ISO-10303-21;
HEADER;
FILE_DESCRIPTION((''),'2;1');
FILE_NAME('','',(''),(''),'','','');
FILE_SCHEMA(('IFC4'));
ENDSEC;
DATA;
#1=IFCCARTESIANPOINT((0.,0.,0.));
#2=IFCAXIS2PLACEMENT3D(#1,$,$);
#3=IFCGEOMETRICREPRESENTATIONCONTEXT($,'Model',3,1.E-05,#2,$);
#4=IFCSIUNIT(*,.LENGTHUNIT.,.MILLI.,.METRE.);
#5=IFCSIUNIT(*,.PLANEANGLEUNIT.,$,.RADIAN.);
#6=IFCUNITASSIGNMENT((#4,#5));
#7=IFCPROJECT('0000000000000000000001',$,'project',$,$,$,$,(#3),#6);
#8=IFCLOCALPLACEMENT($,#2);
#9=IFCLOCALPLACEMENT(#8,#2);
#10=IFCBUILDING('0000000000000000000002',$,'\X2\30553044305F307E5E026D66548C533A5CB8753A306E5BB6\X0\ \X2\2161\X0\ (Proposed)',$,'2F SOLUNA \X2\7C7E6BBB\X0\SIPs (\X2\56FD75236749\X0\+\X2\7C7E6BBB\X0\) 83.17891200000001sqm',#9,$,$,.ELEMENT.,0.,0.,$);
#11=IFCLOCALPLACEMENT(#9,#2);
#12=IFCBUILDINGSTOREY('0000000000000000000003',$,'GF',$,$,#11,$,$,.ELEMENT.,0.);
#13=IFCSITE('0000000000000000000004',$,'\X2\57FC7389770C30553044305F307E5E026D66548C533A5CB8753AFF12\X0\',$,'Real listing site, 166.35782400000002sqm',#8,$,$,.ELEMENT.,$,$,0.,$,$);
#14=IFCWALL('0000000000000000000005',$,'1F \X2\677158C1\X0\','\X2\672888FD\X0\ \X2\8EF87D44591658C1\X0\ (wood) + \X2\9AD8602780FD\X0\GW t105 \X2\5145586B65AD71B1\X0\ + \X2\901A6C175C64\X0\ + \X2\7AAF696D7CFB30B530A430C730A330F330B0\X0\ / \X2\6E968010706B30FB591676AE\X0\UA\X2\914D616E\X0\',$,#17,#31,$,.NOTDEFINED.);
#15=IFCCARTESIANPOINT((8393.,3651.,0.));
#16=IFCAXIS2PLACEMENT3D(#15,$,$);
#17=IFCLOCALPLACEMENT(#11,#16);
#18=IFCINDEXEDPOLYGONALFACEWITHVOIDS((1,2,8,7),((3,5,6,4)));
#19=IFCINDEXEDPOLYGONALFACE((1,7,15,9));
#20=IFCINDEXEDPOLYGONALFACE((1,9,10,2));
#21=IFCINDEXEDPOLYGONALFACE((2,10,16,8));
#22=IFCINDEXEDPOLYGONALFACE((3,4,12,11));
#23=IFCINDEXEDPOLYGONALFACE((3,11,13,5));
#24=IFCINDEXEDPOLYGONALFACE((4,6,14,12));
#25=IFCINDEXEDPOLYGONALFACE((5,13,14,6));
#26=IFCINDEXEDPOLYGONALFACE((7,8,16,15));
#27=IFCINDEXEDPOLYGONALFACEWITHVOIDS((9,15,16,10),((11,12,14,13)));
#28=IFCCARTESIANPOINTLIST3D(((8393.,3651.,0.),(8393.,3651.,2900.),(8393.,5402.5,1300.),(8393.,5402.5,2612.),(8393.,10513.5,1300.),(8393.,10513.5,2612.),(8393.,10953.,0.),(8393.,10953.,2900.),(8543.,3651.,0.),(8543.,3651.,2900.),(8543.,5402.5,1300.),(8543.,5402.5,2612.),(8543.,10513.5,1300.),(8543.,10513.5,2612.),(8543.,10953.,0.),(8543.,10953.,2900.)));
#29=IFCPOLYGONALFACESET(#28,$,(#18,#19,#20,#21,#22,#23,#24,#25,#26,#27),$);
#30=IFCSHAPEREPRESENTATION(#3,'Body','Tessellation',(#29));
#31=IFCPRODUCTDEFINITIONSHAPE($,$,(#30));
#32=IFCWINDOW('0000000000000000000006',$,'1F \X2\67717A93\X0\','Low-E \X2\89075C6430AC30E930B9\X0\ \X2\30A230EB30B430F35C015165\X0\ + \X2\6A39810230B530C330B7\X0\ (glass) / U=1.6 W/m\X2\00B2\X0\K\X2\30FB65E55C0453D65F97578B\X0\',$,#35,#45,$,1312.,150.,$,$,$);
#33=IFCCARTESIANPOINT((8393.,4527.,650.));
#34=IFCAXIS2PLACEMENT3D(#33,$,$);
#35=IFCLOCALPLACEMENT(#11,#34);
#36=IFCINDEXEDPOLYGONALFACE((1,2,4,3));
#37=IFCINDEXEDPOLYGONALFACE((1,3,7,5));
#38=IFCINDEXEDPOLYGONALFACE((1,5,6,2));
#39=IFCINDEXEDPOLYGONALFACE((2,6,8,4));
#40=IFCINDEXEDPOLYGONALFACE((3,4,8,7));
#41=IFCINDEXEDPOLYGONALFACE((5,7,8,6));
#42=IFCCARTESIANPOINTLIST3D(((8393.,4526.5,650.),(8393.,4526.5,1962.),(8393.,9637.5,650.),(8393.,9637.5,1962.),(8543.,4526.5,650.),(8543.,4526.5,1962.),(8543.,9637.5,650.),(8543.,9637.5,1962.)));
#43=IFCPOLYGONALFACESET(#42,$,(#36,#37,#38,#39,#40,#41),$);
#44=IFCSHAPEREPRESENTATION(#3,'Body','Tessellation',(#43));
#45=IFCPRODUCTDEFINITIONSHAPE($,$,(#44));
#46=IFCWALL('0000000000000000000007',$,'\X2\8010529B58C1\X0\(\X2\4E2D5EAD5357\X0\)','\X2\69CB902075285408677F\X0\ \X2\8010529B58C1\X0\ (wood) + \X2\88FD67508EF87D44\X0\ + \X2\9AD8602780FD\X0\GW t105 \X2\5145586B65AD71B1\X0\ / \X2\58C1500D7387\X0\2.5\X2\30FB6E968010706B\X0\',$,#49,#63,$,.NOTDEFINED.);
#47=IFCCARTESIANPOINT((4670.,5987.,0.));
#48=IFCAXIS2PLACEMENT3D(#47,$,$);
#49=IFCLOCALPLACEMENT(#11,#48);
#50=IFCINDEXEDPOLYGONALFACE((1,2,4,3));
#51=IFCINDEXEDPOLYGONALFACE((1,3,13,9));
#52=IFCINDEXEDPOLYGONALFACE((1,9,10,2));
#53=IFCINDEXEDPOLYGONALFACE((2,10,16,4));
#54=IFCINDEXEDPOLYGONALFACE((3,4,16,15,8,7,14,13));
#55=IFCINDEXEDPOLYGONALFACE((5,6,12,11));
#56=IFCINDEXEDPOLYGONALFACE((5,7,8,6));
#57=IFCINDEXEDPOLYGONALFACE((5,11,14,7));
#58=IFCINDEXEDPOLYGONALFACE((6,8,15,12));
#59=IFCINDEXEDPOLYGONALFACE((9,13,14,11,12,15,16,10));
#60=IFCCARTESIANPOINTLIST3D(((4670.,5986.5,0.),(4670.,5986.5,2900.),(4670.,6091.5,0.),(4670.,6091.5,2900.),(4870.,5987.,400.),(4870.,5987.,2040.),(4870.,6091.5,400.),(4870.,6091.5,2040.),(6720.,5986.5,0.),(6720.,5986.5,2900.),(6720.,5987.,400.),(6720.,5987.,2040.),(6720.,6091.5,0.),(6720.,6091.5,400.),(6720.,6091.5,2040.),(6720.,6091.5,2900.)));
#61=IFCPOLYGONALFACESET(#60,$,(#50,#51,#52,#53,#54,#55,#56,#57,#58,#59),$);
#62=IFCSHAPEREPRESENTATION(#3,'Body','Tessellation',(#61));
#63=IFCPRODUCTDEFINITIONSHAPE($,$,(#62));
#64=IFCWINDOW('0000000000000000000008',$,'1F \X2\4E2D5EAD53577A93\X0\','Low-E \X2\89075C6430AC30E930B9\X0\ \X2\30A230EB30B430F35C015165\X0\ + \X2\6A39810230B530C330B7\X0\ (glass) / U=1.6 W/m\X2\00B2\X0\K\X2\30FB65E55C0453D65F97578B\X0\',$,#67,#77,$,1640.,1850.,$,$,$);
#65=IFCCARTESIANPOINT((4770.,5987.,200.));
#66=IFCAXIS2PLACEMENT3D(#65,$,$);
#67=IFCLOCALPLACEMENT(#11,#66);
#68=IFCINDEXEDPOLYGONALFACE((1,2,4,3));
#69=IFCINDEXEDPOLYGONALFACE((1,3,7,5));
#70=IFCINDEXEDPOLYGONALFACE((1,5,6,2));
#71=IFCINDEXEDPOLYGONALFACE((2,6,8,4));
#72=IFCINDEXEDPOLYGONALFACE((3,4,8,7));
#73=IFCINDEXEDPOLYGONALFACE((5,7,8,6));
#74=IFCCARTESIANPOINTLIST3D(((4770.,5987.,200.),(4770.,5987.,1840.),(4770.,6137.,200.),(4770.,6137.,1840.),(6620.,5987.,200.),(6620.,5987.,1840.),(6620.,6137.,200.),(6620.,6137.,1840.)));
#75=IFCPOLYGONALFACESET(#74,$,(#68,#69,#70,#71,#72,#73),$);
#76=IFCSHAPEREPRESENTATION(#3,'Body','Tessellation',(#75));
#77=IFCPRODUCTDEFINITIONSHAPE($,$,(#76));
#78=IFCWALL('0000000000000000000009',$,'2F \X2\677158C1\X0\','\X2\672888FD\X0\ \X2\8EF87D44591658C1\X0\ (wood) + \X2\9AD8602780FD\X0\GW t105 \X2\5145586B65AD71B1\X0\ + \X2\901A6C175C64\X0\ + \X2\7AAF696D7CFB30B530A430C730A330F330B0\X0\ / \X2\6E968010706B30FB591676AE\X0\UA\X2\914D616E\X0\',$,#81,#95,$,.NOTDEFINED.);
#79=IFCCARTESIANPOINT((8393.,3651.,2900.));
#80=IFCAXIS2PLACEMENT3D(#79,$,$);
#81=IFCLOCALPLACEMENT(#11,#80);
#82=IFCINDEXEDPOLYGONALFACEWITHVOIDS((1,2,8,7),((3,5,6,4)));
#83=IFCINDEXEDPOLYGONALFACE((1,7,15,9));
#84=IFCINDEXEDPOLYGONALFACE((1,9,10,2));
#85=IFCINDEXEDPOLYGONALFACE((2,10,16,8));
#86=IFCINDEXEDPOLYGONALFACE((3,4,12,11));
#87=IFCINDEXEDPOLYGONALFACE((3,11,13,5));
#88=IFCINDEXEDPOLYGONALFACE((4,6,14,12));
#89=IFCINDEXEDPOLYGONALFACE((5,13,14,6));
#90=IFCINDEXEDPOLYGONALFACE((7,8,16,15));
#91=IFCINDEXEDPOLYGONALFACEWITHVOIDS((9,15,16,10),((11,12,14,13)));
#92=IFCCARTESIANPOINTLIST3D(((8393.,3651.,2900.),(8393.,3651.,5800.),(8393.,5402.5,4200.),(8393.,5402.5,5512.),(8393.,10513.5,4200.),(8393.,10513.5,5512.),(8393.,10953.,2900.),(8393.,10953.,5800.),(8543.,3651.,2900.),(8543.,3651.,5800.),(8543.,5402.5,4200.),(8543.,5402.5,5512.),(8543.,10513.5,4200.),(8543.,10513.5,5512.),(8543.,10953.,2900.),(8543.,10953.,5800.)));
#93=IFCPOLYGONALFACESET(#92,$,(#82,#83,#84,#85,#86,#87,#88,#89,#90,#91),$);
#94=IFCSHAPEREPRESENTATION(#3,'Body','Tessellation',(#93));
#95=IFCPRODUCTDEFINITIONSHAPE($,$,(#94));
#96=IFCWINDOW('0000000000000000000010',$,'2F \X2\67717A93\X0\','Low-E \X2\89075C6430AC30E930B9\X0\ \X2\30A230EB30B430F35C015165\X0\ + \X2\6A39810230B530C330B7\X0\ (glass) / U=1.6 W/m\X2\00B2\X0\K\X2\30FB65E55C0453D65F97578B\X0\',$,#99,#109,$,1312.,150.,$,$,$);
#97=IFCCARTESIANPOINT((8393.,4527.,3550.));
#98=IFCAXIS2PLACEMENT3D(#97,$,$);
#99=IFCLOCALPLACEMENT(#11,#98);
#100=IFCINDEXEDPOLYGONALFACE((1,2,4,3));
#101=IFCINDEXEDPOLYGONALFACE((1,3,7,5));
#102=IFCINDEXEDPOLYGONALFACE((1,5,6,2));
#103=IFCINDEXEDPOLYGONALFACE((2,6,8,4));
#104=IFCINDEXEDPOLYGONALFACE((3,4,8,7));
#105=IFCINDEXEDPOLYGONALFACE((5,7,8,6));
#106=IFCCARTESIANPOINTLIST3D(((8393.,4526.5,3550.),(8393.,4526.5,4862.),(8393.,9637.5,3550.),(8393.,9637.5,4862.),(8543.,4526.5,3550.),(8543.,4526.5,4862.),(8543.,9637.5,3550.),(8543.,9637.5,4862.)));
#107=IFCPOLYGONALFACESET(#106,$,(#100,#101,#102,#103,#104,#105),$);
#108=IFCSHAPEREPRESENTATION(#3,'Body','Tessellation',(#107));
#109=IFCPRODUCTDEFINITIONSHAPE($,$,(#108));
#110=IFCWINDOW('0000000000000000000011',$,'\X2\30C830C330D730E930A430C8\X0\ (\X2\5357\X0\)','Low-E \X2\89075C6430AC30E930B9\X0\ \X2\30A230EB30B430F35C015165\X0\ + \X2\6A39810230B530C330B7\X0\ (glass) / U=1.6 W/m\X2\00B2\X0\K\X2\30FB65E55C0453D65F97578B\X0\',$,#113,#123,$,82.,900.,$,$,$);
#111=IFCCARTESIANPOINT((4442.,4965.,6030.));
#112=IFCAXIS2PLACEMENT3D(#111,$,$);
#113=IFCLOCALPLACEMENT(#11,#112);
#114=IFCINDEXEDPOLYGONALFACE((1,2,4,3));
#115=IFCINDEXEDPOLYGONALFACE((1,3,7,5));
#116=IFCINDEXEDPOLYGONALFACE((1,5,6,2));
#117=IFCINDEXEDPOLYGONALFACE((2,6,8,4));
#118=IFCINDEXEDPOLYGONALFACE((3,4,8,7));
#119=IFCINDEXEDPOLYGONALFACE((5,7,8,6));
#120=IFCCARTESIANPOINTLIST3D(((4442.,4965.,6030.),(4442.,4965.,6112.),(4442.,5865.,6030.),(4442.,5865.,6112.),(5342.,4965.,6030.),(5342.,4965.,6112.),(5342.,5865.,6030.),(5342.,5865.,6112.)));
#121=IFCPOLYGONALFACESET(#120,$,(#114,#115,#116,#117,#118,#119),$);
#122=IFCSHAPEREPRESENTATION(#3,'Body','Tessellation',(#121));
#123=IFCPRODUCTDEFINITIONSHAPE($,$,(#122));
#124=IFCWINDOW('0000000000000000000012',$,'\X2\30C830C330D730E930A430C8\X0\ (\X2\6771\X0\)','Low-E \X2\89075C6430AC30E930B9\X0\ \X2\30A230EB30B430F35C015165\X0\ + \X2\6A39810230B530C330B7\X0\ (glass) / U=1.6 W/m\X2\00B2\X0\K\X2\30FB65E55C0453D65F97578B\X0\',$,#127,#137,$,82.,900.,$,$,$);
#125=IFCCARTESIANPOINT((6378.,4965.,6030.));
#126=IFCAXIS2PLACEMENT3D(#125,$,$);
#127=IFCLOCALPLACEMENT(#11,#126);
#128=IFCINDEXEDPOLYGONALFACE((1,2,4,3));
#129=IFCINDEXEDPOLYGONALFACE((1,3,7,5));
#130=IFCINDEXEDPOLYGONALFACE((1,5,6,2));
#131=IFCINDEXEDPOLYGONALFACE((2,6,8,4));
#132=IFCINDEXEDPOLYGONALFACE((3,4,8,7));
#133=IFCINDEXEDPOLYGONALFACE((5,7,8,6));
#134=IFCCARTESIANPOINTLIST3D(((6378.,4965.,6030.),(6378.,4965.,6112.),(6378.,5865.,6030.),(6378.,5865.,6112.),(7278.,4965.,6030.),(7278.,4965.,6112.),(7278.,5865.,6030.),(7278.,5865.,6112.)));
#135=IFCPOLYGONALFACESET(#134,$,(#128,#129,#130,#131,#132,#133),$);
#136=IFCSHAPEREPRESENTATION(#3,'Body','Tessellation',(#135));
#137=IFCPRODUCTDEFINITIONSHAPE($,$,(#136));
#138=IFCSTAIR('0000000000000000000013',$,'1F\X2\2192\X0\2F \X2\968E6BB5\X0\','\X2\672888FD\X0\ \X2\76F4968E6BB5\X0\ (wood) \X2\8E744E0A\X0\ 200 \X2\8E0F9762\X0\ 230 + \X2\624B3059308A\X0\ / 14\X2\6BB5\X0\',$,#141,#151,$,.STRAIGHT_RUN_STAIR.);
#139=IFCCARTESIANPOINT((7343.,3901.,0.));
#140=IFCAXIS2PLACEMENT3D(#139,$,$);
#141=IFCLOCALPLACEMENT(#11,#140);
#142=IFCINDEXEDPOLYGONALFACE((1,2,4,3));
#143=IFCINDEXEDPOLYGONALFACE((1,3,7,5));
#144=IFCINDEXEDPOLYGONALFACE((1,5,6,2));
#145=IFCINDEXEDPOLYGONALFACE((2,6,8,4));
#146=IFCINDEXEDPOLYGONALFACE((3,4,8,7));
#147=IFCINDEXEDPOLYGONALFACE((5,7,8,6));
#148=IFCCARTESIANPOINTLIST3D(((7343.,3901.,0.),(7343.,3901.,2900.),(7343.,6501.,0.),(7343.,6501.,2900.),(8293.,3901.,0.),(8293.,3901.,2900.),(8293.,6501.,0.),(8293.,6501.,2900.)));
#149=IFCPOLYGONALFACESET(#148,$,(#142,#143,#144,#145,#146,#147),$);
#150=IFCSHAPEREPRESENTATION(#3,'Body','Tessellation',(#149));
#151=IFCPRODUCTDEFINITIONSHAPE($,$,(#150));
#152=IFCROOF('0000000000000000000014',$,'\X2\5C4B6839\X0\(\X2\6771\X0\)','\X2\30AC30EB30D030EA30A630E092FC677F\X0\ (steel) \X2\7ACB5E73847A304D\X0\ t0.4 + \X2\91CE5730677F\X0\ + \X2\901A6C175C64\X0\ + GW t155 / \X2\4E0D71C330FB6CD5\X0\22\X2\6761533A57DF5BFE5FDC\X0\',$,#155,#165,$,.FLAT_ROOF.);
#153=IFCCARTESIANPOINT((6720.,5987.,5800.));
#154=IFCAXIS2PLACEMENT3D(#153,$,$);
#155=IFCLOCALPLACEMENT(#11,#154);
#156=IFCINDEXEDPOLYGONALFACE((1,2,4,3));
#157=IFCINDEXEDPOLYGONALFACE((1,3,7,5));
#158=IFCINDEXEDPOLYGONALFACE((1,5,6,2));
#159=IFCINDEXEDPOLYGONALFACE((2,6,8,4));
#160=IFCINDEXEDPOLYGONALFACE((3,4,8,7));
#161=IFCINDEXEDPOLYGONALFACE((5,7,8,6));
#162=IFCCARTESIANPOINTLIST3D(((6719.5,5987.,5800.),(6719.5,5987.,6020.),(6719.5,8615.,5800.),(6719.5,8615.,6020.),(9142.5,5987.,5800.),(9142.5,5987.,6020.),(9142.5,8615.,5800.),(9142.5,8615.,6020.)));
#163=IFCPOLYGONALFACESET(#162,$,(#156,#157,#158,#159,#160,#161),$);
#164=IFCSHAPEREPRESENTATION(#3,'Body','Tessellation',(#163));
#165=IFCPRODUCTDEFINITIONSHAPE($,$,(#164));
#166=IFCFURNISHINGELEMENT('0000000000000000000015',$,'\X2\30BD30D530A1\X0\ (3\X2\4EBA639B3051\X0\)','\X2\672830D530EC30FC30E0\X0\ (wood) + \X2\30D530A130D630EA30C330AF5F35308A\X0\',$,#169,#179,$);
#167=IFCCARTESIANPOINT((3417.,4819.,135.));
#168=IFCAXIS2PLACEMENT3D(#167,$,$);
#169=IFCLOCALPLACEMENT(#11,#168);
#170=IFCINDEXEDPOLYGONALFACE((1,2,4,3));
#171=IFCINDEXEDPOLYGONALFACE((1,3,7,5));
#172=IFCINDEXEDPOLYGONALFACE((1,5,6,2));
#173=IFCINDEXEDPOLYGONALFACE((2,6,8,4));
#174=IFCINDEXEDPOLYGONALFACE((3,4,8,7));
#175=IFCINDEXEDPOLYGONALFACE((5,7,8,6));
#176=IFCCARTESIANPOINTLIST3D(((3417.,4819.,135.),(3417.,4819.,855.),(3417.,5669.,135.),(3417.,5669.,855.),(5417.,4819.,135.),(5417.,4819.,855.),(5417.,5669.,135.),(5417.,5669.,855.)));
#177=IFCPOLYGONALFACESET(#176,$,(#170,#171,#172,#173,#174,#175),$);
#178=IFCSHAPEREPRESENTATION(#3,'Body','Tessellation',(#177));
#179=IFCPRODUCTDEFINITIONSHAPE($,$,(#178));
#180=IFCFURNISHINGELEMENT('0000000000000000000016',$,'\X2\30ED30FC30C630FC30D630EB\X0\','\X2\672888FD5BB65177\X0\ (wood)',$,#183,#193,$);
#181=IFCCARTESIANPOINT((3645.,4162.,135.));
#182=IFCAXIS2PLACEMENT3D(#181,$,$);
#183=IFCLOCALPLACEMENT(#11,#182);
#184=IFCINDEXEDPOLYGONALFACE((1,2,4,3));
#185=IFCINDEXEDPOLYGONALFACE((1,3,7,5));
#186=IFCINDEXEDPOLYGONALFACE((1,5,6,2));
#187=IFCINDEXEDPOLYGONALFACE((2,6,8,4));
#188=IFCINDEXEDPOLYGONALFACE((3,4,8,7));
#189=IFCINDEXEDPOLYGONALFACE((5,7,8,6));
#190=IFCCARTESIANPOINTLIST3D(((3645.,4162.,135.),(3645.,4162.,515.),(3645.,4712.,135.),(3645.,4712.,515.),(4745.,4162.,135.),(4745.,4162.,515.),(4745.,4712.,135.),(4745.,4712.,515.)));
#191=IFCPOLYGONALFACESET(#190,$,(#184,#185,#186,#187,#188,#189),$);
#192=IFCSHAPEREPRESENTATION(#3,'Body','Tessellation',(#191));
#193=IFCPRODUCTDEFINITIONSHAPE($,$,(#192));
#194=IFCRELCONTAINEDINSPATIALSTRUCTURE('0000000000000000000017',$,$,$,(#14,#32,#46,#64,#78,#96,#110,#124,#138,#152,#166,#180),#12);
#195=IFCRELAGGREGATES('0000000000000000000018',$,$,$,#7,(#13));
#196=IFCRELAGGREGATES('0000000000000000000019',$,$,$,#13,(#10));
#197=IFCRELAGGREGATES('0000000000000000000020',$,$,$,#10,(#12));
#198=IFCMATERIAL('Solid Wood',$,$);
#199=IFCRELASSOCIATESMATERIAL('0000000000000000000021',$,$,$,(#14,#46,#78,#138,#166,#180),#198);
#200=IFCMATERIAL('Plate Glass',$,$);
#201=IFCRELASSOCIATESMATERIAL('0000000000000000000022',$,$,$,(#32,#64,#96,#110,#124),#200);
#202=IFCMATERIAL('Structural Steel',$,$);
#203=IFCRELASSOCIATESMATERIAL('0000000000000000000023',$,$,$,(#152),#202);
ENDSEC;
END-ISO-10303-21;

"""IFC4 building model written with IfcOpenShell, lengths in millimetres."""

from ifc_helpers import new_model, si_unit, frame, frame_2d, origin, place, context, project, spatial, rectangle, extrude, material, element, fill, save


model = new_model("IFC4")

# Units and contexts
model_context = context("Model", 3, precision=1e-05, world=origin())
ifc_project = project(units=[si_unit("LENGTHUNIT", "METRE", prefix="MILLI"), si_unit("PLANEANGLEUNIT", "RADIAN")], contexts=[model_context])

# Site, building, storey
site_placement = place(None, origin())
site = spatial("IfcSite", under=ifc_project, at=site_placement, Name="埼玉県さいたま市浦和区岸町２", ObjectType="Real listing site, 166.35782400000002sqm", CompositionType="ELEMENT", RefElevation=0.0)
building_placement = place(site_placement, origin())
building = spatial("IfcBuilding", under=site, at=building_placement, Name="さいたま市浦和区岸町の家 Ⅱ (Proposed)", ObjectType="2F SOLUNA 籾殻SIPs (国産杉+籾殻) 83.17891200000001sqm", CompositionType="ELEMENT", ElevationOfRefHeight=0.0, ElevationOfTerrain=0.0)
storey_placement = place(building_placement, origin())
storey = spatial("IfcBuildingStorey", under=building, at=storey_placement, Name="GF", CompositionType="ELEMENT", Elevation=0.0)

# Shared definitions
ifc_material_1 = material(Name="Solid Wood")

# Walls, openings, windows
wall_1_placement = place(storey_placement, frame((8393.0, 3651.0, 0.0)))
wall_1 = element("IfcWall", 1, at=wall_1_placement, inside=storey, material=ifc_material_1, Name="1F 東壁", Description="木製 軸組外壁 (wood) + 高性能GW t105 充填断熱 + 通気層 + 窯業系サイディング / 準耐火・外皮UA配慮", PredefinedType="NOTDEFINED", context=model_context, shape_type="SweptSolid", body=[
    extrude(rectangle(XDim=150.0, YDim=7302.0, at=frame_2d((75.0, 3651.0))), frame((8393.0, 3651.0, 0.0)), (0.0, 0.0, 1.0), 2900.0),
])
opening_1_placement = place(storey_placement, frame((8393.0, 4527.0, 650.0)))
opening_1 = element("IfcOpeningElement", 2, at=opening_1_placement, cuts=wall_1, PredefinedType="NOTDEFINED", context=model_context, shape_type="SweptSolid", body=[
    extrude(rectangle(XDim=150.0, YDim=5111.0, at=frame_2d((75.0, 2555.0))), frame((8393.0, 4527.0, 650.0)), (0.0, 0.0, 1.0), 1312.0),
])
ifc_material_2 = material(Name="Plate Glass")
window_1_placement = place(storey_placement, frame((8393.0, 4527.0, 650.0)))
window_1 = element("IfcWindow", 3, at=window_1_placement, inside=storey, material=ifc_material_2, Name="1F 東窓", Description="Low-E 複層ガラス アルゴン封入 + 樹脂サッシ (glass) / U=1.6 W/m²K・日射取得型", OverallHeight=1312.0, OverallWidth=150.0, context=model_context, shape_type="SweptSolid", body=[
    extrude(rectangle(XDim=150.0, YDim=5111.0, at=frame_2d((75.0, 2555.0))), frame((8393.0, 4527.0, 650.0)), (0.0, 0.0, 1.0), 1312.0),
])
fill(opening_1, window_1)
wall_2_placement = place(storey_placement, frame((4670.0, 5987.0, 0.0)))
wall_2 = element("IfcWall", 4, at=wall_2_placement, inside=storey, material=ifc_material_1, Name="耐力壁(中庭南)", Description="構造用合板 耐力壁 (wood) + 製材軸組 + 高性能GW t105 充填断熱 / 壁倍率2.5・準耐火", PredefinedType="NOTDEFINED", context=model_context, shape_type="SweptSolid", body=[
    extrude(rectangle(XDim=2050.0, YDim=105.0, at=frame_2d((1025.0, 52.0))), frame((4670.0, 5987.0, 0.0)), (0.0, 0.0, 1.0), 2900.0),
])
opening_2_placement = place(storey_placement, frame((4770.0, 5987.0, 200.0)))
opening_2 = element("IfcOpeningElement", 5, at=opening_2_placement, cuts=wall_2, PredefinedType="NOTDEFINED", context=model_context, shape_type="SweptSolid", body=[
    extrude(rectangle(XDim=1850.0, YDim=150.0, at=frame_2d((925.0, 75.0))), frame((4770.0, 5987.0, 200.0)), (0.0, 0.0, 1.0), 1640.0),
])
window_2_placement = place(storey_placement, frame((4770.0, 5987.0, 200.0)))
window_2 = element("IfcWindow", 6, at=window_2_placement, inside=storey, material=ifc_material_2, Name="1F 中庭南窓", Description="Low-E 複層ガラス アルゴン封入 + 樹脂サッシ (glass) / U=1.6 W/m²K・日射取得型", OverallHeight=1640.0, OverallWidth=1850.0, context=model_context, shape_type="SweptSolid", body=[
    extrude(rectangle(XDim=1850.0, YDim=150.0, at=frame_2d((925.0, 75.0))), frame((4770.0, 5987.0, 200.0)), (0.0, 0.0, 1.0), 1640.0),
])
fill(opening_2, window_2)

# Wall, opening, window
wall_3_placement = place(storey_placement, frame((8393.0, 3651.0, 2900.0)))
wall_3 = element("IfcWall", 7, at=wall_3_placement, inside=storey, material=ifc_material_1, Name="2F 東壁", Description="木製 軸組外壁 (wood) + 高性能GW t105 充填断熱 + 通気層 + 窯業系サイディング / 準耐火・外皮UA配慮", PredefinedType="NOTDEFINED", context=model_context, shape_type="SweptSolid", body=[
    extrude(rectangle(XDim=150.0, YDim=7302.0, at=frame_2d((75.0, 3651.0))), frame((8393.0, 3651.0, 2900.0)), (0.0, 0.0, 1.0), 2900.0),
])
opening_3_placement = place(storey_placement, frame((8393.0, 4527.0, 3550.0)))
opening_3 = element("IfcOpeningElement", 8, at=opening_3_placement, cuts=wall_3, PredefinedType="NOTDEFINED", context=model_context, shape_type="SweptSolid", body=[
    extrude(rectangle(XDim=150.0, YDim=5111.0, at=frame_2d((75.0, 2555.0))), frame((8393.0, 4527.0, 3550.0)), (0.0, 0.0, 1.0), 1312.0),
])
window_3_placement = place(storey_placement, frame((8393.0, 4527.0, 3550.0)))
window_3 = element("IfcWindow", 9, at=window_3_placement, inside=storey, material=ifc_material_2, Name="2F 東窓", Description="Low-E 複層ガラス アルゴン封入 + 樹脂サッシ (glass) / U=1.6 W/m²K・日射取得型", OverallHeight=1312.0, OverallWidth=150.0, context=model_context, shape_type="SweptSolid", body=[
    extrude(rectangle(XDim=150.0, YDim=5111.0, at=frame_2d((75.0, 2555.0))), frame((8393.0, 4527.0, 3550.0)), (0.0, 0.0, 1.0), 1312.0),
])
fill(opening_3, window_3)

# Windows
window_4_placement = place(storey_placement, frame((4442.0, 4965.0, 6030.0)))
element("IfcWindow", 10, at=window_4_placement, inside=storey, material=ifc_material_2, Name="トップライト (南)", Description="Low-E 複層ガラス アルゴン封入 + 樹脂サッシ (glass) / U=1.6 W/m²K・日射取得型", OverallHeight=82.0, OverallWidth=900.0, context=model_context, shape_type="SweptSolid", body=[
    extrude(rectangle(XDim=900.0, YDim=900.0, at=frame_2d((450.0, 450.0))), frame((4442.0, 4965.0, 6030.0)), (0.0, 0.0, 1.0), 82.0),
])
window_5_placement = place(storey_placement, frame((6378.0, 4965.0, 6030.0)))
element("IfcWindow", 11, at=window_5_placement, inside=storey, material=ifc_material_2, Name="トップライト (東)", Description="Low-E 複層ガラス アルゴン封入 + 樹脂サッシ (glass) / U=1.6 W/m²K・日射取得型", OverallHeight=82.0, OverallWidth=900.0, context=model_context, shape_type="SweptSolid", body=[
    extrude(rectangle(XDim=900.0, YDim=900.0, at=frame_2d((450.0, 450.0))), frame((6378.0, 4965.0, 6030.0)), (0.0, 0.0, 1.0), 82.0),
])

# Stair
stair_placement = place(storey_placement, frame((7343.0, 3901.0, 0.0)))
element("IfcStair", 12, at=stair_placement, inside=storey, material=ifc_material_1, Name="1F→2F 階段", Description="木製 直階段 (wood) 蹴上 200 踏面 230 + 手すり / 14段", PredefinedType="STRAIGHT_RUN_STAIR", context=model_context, shape_type="SweptSolid", body=[
    extrude(rectangle(XDim=950.0, YDim=2600.0, at=frame_2d((475.0, 1300.0))), frame((7343.0, 3901.0, 0.0)), (0.0, 0.0, 1.0), 2900.0),
])

# Roof
ifc_material_3 = material(Name="Structural Steel")
roof_placement = place(storey_placement, frame((6720.0, 5987.0, 5800.0)))
element("IfcRoof", 13, at=roof_placement, inside=storey, material=ifc_material_3, Name="屋根(東)", Description="ガルバリウム鋼板 (steel) 立平葺き t0.4 + 野地板 + 通気層 + GW t155 / 不燃・法22条区域対応", PredefinedType="FLAT_ROOF", context=model_context, shape_type="SweptSolid", body=[
    extrude(rectangle(XDim=2423.0, YDim=2628.0, at=frame_2d((1211.0, 1314.0))), frame((6720.0, 5987.0, 5800.0)), (0.0, 0.0, 1.0), 220.0),
])

# Furnishing elements
furnishing_1_placement = place(storey_placement, frame((3417.0, 4819.0, 135.0)))
element("IfcFurnishingElement", 14, at=furnishing_1_placement, inside=storey, material=ifc_material_1, Name="ソファ (3人掛け)", Description="木フレーム (wood) + ファブリック張り", context=model_context, shape_type="SweptSolid", body=[
    extrude(rectangle(XDim=2000.0, YDim=850.0, at=frame_2d((1000.0, 425.0))), frame((3417.0, 4819.0, 135.0)), (0.0, 0.0, 1.0), 720.0),
])
furnishing_2_placement = place(storey_placement, frame((3645.0, 4162.0, 135.0)))
element("IfcFurnishingElement", 15, at=furnishing_2_placement, inside=storey, material=ifc_material_1, Name="ローテーブル", Description="木製家具 (wood)", context=model_context, shape_type="SweptSolid", body=[
    extrude(rectangle(XDim=1100.0, YDim=550.0, at=frame_2d((550.0, 275.0))), frame((3645.0, 4162.0, 135.0)), (0.0, 0.0, 1.0), 380.0),
])

save(model, "model.ifc")
